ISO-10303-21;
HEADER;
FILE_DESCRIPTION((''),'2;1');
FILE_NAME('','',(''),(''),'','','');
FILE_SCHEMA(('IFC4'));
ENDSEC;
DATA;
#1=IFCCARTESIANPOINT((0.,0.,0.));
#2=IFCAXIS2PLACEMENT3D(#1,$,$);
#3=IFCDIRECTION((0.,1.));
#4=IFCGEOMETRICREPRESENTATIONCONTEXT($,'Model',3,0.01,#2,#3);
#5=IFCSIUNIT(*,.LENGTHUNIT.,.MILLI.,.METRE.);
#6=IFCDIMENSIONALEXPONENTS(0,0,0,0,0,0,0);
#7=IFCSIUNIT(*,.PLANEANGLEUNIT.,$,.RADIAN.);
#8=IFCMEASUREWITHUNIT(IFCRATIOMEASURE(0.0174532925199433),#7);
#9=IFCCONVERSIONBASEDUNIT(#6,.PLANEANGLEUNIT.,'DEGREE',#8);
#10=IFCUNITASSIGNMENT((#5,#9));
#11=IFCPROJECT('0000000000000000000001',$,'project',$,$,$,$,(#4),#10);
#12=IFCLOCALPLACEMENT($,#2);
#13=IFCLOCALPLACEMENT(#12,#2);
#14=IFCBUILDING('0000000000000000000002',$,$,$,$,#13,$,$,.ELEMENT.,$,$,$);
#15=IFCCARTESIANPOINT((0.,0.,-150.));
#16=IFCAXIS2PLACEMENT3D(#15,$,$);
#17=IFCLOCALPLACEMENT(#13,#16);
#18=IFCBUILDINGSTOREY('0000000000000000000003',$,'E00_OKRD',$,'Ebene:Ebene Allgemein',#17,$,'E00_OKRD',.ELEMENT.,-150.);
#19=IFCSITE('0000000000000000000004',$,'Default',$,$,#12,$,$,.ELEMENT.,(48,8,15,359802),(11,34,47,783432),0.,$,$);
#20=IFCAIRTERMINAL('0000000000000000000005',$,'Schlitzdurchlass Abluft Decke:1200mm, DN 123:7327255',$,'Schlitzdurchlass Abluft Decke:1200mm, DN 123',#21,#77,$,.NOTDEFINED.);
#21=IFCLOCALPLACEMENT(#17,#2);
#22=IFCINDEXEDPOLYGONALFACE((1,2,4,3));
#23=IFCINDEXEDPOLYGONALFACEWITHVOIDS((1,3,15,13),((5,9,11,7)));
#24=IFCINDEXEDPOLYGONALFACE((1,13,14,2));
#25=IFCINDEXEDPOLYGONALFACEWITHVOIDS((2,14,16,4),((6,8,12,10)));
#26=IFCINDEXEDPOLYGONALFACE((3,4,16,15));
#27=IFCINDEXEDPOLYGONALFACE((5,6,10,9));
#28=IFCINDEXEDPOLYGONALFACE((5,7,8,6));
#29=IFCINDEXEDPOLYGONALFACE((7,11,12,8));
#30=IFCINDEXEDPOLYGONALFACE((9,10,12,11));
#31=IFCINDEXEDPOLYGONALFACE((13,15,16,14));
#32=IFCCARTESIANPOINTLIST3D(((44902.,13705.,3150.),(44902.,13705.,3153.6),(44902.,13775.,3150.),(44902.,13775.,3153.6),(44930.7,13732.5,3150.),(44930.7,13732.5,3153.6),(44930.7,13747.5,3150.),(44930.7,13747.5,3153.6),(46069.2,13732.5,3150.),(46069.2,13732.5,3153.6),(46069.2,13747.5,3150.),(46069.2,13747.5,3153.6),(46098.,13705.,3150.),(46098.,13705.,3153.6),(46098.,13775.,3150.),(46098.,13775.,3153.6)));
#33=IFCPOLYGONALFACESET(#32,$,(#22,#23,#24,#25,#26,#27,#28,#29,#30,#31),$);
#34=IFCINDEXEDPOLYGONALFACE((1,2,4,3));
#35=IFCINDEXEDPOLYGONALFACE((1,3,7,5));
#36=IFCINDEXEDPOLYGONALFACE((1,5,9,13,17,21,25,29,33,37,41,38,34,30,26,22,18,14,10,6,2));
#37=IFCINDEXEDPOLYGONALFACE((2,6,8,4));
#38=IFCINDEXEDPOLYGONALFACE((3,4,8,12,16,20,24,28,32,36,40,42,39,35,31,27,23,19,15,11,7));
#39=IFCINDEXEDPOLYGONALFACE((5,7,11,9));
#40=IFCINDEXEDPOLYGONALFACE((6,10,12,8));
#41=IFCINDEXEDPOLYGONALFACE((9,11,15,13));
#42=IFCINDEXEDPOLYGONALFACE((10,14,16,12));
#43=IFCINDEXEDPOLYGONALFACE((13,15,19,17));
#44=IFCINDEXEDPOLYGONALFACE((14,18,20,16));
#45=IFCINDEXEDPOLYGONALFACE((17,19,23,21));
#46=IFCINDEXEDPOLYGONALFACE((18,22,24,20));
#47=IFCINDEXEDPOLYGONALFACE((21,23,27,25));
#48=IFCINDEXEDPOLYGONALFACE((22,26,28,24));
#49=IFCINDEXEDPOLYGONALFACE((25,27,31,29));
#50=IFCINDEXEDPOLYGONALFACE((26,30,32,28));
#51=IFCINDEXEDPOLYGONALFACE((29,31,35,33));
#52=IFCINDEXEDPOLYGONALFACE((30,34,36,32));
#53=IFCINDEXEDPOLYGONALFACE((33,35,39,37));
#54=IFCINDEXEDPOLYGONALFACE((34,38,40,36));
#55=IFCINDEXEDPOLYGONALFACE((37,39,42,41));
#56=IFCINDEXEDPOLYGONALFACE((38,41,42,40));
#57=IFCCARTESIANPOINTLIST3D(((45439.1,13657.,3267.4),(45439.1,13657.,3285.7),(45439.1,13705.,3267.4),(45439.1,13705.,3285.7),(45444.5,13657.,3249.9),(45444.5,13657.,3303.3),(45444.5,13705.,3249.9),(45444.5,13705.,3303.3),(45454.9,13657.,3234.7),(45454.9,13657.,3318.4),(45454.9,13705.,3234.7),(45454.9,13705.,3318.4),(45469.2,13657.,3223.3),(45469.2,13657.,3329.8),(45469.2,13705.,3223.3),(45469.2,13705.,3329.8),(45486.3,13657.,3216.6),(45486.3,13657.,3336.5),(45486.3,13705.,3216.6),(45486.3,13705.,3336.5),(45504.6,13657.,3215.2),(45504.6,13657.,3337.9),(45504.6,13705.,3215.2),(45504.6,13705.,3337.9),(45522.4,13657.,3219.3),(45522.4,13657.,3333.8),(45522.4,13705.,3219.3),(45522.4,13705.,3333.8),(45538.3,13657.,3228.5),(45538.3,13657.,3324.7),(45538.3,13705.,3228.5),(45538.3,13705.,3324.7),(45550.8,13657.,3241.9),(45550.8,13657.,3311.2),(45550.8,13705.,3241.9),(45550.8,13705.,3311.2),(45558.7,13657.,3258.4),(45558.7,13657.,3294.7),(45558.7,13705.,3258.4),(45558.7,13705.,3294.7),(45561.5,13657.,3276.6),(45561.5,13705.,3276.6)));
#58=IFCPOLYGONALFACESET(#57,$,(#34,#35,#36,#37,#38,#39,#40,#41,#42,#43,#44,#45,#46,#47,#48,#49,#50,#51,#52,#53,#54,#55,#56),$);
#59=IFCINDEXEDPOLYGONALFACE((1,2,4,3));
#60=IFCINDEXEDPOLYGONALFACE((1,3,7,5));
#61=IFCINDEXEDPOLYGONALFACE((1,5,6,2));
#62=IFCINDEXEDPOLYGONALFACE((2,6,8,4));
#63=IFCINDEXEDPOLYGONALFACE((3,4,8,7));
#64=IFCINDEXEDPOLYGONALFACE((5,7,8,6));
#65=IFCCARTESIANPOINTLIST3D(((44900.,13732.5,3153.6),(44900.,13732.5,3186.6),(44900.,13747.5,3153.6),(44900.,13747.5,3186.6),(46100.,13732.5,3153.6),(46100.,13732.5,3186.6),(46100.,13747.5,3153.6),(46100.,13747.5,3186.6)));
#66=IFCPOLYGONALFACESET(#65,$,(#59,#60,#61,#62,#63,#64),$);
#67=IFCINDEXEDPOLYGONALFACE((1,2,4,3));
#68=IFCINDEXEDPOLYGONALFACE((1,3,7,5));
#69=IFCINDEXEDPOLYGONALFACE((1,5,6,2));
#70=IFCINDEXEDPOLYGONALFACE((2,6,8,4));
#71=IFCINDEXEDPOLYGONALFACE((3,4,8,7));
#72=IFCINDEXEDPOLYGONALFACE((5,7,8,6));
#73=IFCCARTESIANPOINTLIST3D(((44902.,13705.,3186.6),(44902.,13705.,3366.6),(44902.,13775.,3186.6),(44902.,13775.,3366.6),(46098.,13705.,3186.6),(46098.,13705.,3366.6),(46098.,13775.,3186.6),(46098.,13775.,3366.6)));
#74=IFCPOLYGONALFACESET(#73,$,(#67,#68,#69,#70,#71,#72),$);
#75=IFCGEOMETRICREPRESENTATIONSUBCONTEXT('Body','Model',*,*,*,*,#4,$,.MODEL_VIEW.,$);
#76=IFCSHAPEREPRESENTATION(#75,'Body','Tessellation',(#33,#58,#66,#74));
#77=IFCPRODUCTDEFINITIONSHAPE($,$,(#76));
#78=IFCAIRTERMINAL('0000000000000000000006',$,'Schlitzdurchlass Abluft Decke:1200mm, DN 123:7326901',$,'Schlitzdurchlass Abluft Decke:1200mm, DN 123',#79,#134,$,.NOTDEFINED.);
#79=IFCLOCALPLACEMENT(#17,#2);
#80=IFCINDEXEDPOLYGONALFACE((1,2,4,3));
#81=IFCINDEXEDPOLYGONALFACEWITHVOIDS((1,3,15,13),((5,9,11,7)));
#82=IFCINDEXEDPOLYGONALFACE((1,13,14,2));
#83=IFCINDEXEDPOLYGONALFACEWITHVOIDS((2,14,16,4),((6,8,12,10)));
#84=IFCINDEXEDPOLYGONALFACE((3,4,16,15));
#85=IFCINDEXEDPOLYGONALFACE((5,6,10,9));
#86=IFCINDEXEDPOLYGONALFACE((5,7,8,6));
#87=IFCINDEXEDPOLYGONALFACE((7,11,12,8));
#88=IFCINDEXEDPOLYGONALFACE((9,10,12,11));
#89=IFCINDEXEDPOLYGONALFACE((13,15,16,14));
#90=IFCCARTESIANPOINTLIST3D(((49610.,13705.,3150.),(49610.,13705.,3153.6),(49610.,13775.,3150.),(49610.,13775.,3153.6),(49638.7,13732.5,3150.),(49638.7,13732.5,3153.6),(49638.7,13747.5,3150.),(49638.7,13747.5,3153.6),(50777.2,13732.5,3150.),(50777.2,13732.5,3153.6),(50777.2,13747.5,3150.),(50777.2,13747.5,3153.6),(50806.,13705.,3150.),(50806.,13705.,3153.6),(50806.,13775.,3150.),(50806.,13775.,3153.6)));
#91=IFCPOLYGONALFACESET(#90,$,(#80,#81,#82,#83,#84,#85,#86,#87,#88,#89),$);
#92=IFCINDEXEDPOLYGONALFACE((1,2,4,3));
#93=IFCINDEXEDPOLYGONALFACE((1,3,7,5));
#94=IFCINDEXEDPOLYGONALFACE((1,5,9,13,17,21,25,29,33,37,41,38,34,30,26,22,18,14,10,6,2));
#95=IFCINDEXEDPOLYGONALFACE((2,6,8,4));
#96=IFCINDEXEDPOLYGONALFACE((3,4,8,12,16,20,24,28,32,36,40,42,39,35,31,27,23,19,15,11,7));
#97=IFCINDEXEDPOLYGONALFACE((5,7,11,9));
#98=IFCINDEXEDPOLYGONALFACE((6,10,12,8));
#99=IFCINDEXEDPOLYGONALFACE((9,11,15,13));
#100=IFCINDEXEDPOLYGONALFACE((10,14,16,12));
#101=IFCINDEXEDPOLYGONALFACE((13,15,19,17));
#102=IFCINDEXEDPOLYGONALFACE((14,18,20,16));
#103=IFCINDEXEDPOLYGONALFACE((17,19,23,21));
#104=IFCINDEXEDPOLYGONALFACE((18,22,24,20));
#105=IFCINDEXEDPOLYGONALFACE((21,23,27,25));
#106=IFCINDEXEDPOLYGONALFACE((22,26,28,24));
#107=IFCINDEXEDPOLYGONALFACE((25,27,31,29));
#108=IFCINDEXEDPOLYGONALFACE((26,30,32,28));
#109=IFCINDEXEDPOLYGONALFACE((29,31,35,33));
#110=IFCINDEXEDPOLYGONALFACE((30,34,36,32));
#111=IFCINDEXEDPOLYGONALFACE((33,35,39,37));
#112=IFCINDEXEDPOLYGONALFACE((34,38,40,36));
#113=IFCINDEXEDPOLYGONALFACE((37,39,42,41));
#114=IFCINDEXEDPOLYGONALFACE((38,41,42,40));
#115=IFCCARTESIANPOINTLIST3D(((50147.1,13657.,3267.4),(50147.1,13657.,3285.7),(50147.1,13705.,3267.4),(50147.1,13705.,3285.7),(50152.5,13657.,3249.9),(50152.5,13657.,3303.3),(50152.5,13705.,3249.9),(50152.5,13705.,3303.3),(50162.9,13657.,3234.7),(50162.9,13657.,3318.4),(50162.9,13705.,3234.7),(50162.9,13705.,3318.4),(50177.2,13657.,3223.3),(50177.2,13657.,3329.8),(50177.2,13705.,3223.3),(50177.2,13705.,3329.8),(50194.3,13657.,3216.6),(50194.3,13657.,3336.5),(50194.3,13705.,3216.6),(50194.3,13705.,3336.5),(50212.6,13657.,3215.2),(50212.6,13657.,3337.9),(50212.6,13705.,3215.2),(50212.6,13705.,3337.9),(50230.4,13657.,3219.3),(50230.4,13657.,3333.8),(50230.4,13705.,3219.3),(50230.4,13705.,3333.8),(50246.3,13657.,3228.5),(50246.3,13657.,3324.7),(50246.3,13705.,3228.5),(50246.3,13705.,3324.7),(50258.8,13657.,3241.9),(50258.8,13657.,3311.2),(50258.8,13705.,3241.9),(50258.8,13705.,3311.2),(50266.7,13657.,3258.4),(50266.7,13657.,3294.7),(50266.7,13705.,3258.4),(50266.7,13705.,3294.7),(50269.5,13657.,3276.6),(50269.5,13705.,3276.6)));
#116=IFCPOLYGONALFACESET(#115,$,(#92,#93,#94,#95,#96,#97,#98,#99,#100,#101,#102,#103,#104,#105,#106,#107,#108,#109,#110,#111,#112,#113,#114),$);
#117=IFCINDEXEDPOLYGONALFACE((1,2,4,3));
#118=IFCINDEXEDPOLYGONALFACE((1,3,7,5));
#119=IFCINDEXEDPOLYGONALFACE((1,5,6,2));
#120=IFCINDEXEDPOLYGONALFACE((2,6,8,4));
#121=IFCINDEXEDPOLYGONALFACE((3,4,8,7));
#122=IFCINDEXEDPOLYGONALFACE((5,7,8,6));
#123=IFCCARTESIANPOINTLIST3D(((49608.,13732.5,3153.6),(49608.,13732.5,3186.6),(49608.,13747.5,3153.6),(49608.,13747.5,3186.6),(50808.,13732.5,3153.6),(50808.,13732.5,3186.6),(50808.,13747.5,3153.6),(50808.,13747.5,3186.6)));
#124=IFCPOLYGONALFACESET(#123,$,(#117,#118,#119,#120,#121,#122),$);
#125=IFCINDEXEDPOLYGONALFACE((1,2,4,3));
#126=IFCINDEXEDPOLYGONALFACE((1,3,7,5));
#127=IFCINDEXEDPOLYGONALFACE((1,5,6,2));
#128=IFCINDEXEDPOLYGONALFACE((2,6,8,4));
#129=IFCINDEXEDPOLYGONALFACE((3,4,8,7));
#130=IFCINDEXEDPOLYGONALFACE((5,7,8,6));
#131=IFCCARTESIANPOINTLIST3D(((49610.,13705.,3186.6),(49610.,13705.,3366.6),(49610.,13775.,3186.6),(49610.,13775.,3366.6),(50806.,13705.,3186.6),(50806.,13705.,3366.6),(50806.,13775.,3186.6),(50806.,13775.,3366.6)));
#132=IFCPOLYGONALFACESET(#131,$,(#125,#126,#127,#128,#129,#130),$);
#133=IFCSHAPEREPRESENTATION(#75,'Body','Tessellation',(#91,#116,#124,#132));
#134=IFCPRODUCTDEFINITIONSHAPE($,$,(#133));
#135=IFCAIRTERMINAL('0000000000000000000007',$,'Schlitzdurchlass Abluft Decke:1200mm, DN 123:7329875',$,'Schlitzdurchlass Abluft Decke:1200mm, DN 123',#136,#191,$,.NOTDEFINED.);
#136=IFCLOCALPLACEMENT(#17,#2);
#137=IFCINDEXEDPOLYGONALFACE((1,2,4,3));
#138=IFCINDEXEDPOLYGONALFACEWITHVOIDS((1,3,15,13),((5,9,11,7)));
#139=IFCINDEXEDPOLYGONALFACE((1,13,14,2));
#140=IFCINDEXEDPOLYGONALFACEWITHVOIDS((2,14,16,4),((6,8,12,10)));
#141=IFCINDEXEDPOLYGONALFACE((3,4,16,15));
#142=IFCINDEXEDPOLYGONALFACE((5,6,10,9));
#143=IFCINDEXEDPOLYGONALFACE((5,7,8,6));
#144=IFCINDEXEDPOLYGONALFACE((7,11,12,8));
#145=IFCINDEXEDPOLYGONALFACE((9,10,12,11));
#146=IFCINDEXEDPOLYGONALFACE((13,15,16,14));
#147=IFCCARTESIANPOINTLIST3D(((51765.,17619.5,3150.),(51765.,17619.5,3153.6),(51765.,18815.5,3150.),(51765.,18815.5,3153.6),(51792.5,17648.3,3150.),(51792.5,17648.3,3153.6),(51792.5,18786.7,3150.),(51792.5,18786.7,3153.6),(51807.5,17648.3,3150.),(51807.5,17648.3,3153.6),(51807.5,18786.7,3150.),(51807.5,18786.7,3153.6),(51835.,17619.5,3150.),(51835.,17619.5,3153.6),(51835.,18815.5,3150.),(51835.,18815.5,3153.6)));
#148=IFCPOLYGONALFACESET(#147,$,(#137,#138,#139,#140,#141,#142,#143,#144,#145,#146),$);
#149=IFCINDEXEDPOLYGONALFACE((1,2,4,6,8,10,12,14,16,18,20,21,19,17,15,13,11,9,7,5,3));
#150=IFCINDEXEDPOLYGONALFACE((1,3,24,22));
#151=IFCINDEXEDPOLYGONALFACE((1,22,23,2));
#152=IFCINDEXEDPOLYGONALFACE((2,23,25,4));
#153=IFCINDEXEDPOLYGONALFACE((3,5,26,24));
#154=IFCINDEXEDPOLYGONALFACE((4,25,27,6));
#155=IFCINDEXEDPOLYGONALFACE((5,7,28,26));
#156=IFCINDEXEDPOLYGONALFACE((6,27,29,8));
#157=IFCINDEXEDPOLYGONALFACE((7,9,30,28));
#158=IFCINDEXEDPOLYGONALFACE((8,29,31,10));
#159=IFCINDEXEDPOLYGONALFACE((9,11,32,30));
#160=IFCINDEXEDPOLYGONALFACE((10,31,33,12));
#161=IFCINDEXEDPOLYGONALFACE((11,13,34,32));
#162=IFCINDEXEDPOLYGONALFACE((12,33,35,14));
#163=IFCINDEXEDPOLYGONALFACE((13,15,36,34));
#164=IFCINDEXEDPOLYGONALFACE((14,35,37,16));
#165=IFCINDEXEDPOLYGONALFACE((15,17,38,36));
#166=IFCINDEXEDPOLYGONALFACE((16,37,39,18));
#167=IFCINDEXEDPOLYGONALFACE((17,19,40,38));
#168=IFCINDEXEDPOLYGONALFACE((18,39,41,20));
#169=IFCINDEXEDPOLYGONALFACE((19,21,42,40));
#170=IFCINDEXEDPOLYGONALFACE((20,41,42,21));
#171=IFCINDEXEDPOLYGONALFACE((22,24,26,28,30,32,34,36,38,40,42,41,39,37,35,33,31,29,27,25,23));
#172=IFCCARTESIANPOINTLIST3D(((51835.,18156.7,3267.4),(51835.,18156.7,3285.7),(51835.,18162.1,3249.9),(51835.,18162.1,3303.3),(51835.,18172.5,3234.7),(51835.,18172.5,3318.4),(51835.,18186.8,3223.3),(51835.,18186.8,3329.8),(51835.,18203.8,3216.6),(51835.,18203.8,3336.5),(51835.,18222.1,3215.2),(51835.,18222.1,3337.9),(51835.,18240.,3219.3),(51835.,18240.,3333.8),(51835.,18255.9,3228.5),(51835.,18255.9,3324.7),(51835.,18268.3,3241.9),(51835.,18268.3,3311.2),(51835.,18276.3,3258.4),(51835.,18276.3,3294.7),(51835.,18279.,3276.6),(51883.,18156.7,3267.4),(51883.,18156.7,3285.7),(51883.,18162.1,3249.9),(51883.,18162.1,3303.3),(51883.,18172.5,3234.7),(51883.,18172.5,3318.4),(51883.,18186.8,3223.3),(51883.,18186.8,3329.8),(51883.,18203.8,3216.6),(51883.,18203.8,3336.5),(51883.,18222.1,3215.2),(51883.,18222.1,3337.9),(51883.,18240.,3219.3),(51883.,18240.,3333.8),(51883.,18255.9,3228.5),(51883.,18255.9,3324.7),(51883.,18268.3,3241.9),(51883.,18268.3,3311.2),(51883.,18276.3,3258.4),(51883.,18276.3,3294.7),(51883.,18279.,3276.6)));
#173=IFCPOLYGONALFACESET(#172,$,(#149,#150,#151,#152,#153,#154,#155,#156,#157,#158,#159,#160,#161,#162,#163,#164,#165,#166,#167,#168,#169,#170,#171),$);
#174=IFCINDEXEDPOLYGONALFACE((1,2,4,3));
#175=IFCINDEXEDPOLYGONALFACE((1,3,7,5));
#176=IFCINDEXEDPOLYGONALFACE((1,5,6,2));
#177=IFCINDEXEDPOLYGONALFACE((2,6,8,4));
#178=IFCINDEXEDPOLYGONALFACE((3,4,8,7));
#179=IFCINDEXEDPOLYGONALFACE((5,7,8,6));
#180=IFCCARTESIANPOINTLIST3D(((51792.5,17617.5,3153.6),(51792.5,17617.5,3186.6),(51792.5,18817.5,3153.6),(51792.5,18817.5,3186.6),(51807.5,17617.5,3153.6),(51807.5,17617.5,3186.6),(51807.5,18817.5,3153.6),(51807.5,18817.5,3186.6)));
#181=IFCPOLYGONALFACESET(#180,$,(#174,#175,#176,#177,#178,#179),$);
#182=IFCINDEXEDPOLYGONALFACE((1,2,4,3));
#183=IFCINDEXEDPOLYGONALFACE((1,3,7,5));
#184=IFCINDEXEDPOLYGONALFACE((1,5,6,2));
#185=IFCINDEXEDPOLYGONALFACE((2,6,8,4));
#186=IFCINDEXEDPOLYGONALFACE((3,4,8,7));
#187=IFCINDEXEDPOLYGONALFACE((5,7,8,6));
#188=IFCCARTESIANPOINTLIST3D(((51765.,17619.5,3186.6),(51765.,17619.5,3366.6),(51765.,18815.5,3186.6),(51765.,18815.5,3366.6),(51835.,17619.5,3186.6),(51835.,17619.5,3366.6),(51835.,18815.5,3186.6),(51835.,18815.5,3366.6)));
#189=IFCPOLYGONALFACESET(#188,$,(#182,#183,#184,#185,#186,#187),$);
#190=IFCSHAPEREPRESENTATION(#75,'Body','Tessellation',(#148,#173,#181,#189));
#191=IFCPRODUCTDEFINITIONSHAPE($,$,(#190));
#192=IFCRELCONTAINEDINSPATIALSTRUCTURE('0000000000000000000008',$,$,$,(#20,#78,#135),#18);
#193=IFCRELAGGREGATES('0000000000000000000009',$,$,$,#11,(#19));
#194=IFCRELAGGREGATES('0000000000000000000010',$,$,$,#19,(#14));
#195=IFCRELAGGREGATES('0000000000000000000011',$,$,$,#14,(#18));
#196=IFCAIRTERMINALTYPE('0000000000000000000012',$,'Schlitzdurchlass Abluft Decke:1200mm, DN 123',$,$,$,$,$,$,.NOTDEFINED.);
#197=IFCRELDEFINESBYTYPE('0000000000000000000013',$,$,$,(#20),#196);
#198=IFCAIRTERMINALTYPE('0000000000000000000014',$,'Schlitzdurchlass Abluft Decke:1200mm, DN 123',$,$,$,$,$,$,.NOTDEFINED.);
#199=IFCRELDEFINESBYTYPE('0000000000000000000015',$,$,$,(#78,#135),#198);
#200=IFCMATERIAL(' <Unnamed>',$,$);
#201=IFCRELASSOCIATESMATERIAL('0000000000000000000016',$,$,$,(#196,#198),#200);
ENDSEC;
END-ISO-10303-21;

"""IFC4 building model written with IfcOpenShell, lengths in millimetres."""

from ifc_helpers import new_model, entity, si_unit, converted_unit, direction, frame, frame_2d, origin, origin_2d_with_axis, place, context, subcontext, project, spatial, polyline, rectangle, circle, outline, extrude, source, transform, mapped, material, type_object, type_shapes, element, save


model = new_model("IFC4")

# Units and contexts
model_context = context("Model", 3, precision=0.01, world=origin(), true_north=direction((0.0, 1.0)))
body_context = subcontext(model_context, "Body", "Model", "MODEL_VIEW")
ifc_project = project(units=[si_unit("LENGTHUNIT", "METRE", prefix="MILLI"), converted_unit("PLANEANGLEUNIT", "DEGREE", entity("IfcRatioMeasure", 0.0174532925199433), si_unit("PLANEANGLEUNIT", "RADIAN"), dimensions=[0, 0, 0, 0, 0, 0, 0])], contexts=[model_context])

# Site, building, storey
site_placement = place(None, origin())
site = spatial("IfcSite", under=ifc_project, at=site_placement, Name="Default", CompositionType="ELEMENT", RefLatitude=(48, 8, 15, 359802), RefLongitude=(11, 34, 47, 783432), RefElevation=0.0)
building_placement = place(site_placement, origin())
building = spatial("IfcBuilding", under=site, at=building_placement, CompositionType="ELEMENT")
storey_placement = place(building_placement, frame((0.0, 0.0, -150.0)))
storey = spatial("IfcBuildingStorey", under=building, at=storey_placement, Name="E00_OKRD", ObjectType="Ebene:Ebene Allgemein", LongName="E00_OKRD", CompositionType="ELEMENT", Elevation=-150.0)

# Air terminals
ifc_material_1 = material(Name=" <Unnamed>")
air_terminal_type_1 = type_object("IfcAirTerminalType", Name="Schlitzdurchlass Abluft Decke:1200mm, DN 123", PredefinedType="NOTDEFINED", material=ifc_material_1)
shared_shape_1 = source(origin(), body_context, "Body", "SweptSolid", [
    extrude(outline(polyline([(-598.0, -35.0), (598.0, -35.0), (598.0, 35.0), (-598.0, 35.0), (-598.0, -35.0)]), holes=[polyline([(-569.2, -7.5), (-569.2, 7.5), (569.2, 7.5), (569.2, -7.5), (-569.2, -7.5)])]), frame((0.0, 0.0, 0.0), z_axis=(0.0, 0.0, 1.0), x_axis=(-1.0, 0.0, 0.0)), (0.0, 0.0, 1.0), 3.6),
    extrude(circle(Radius=61.5, at=frame_2d((0.0, 0.0), x_axis=(1.0, 0.0))), frame((0.0, 35.0, 126.6), z_axis=(0.0, 1.0, 0.0), x_axis=(-1.0, 0.0, 0.0)), (0.0, 0.0, 1.0), 48.0),
    extrude(rectangle(XDim=1200.0, YDim=15.0, at=origin_2d_with_axis()), frame((0.0, 0.0, 3.6), z_axis=(0.0, 0.0, 1.0), x_axis=(-1.0, 0.0, 0.0)), (0.0, 0.0, 1.0), 33.0),
    extrude(rectangle(XDim=1196.0, YDim=70.0, at=origin_2d_with_axis()), frame((0.0, 0.0, 36.6), z_axis=(0.0, 0.0, 1.0), x_axis=(-1.0, 0.0, 0.0)), (0.0, 0.0, 1.0), 180.0),
])
type_shapes(air_terminal_type_1, [shared_shape_1])
air_terminal_1_placement = place(storey_placement, frame((45500.0, 13740.0, 3150.0), z_axis=(0.0, 0.0, 1.0), x_axis=(-1.0, 0.0, 0.0)))
element("IfcAirTerminal", 1, at=air_terminal_1_placement, inside=storey, type_object=air_terminal_type_1, Name="Schlitzdurchlass Abluft Decke:1200mm, DN 123:7327255", ObjectType="Schlitzdurchlass Abluft Decke:1200mm, DN 123", PredefinedType="NOTDEFINED", context=body_context, shape_type="MappedRepresentation", body=[
    mapped(shared_shape_1, transform((0.0, 0.0, 0.0), scale=1.0)),
])
air_terminal_type_2 = type_object("IfcAirTerminalType", Name="Schlitzdurchlass Abluft Decke:1200mm, DN 123", PredefinedType="NOTDEFINED", material=ifc_material_1)
shared_shape_2 = source(origin(), body_context, "Body", "SweptSolid", [
    extrude(outline(polyline([(-598.0, -35.0), (598.0, -35.0), (598.0, 35.0), (-598.0, 35.0), (-598.0, -35.0)]), holes=[polyline([(-569.2, -7.5), (-569.2, 7.5), (569.2, 7.5), (569.2, -7.5), (-569.2, -7.5)])]), frame((0.0, 0.0, 0.0), z_axis=(0.0, 0.0, 1.0), x_axis=(-1.0, 0.0, 0.0)), (0.0, 0.0, 1.0), 3.6),
    extrude(circle(Radius=61.5, at=frame_2d((0.0, 0.0), x_axis=(1.0, 0.0))), frame((0.0, 35.0, 126.6), z_axis=(0.0, 1.0, 0.0), x_axis=(-1.0, 0.0, 0.0)), (0.0, 0.0, 1.0), 48.0),
    extrude(rectangle(XDim=1200.0, YDim=15.0, at=origin_2d_with_axis()), frame((0.0, 0.0, 3.6), z_axis=(0.0, 0.0, 1.0), x_axis=(-1.0, 0.0, 0.0)), (0.0, 0.0, 1.0), 33.0),
    extrude(rectangle(XDim=1196.0, YDim=70.0, at=origin_2d_with_axis()), frame((0.0, 0.0, 36.6), z_axis=(0.0, 0.0, 1.0), x_axis=(-1.0, 0.0, 0.0)), (0.0, 0.0, 1.0), 180.0),
])
type_shapes(air_terminal_type_2, [shared_shape_2])
for number, where, z_axis, x_axis, name in (
    (2, (50208.0, 13740.0, 3150.0), (0.0, 0.0, 1.0), (-1.0, 0.0, 0.0), "Schlitzdurchlass Abluft Decke:1200mm, DN 123:7326901"),
    (3, (51800.0, 18217.5, 3150.0), (0.0, 0.0, 1.0), (0.0, -1.0, 0.0), "Schlitzdurchlass Abluft Decke:1200mm, DN 123:7329875"),
):
    element("IfcAirTerminal", number, at=place(storey_placement, frame(where, z_axis=z_axis, x_axis=x_axis)), inside=storey, type_object=air_terminal_type_2, Name=name, ObjectType="Schlitzdurchlass Abluft Decke:1200mm, DN 123", PredefinedType="NOTDEFINED", context=body_context, shape_type="MappedRepresentation", body=[
        mapped(shared_shape_2, transform((0.0, 0.0, 0.0), scale=1.0)),
    ])

save(model, "model.ifc")
